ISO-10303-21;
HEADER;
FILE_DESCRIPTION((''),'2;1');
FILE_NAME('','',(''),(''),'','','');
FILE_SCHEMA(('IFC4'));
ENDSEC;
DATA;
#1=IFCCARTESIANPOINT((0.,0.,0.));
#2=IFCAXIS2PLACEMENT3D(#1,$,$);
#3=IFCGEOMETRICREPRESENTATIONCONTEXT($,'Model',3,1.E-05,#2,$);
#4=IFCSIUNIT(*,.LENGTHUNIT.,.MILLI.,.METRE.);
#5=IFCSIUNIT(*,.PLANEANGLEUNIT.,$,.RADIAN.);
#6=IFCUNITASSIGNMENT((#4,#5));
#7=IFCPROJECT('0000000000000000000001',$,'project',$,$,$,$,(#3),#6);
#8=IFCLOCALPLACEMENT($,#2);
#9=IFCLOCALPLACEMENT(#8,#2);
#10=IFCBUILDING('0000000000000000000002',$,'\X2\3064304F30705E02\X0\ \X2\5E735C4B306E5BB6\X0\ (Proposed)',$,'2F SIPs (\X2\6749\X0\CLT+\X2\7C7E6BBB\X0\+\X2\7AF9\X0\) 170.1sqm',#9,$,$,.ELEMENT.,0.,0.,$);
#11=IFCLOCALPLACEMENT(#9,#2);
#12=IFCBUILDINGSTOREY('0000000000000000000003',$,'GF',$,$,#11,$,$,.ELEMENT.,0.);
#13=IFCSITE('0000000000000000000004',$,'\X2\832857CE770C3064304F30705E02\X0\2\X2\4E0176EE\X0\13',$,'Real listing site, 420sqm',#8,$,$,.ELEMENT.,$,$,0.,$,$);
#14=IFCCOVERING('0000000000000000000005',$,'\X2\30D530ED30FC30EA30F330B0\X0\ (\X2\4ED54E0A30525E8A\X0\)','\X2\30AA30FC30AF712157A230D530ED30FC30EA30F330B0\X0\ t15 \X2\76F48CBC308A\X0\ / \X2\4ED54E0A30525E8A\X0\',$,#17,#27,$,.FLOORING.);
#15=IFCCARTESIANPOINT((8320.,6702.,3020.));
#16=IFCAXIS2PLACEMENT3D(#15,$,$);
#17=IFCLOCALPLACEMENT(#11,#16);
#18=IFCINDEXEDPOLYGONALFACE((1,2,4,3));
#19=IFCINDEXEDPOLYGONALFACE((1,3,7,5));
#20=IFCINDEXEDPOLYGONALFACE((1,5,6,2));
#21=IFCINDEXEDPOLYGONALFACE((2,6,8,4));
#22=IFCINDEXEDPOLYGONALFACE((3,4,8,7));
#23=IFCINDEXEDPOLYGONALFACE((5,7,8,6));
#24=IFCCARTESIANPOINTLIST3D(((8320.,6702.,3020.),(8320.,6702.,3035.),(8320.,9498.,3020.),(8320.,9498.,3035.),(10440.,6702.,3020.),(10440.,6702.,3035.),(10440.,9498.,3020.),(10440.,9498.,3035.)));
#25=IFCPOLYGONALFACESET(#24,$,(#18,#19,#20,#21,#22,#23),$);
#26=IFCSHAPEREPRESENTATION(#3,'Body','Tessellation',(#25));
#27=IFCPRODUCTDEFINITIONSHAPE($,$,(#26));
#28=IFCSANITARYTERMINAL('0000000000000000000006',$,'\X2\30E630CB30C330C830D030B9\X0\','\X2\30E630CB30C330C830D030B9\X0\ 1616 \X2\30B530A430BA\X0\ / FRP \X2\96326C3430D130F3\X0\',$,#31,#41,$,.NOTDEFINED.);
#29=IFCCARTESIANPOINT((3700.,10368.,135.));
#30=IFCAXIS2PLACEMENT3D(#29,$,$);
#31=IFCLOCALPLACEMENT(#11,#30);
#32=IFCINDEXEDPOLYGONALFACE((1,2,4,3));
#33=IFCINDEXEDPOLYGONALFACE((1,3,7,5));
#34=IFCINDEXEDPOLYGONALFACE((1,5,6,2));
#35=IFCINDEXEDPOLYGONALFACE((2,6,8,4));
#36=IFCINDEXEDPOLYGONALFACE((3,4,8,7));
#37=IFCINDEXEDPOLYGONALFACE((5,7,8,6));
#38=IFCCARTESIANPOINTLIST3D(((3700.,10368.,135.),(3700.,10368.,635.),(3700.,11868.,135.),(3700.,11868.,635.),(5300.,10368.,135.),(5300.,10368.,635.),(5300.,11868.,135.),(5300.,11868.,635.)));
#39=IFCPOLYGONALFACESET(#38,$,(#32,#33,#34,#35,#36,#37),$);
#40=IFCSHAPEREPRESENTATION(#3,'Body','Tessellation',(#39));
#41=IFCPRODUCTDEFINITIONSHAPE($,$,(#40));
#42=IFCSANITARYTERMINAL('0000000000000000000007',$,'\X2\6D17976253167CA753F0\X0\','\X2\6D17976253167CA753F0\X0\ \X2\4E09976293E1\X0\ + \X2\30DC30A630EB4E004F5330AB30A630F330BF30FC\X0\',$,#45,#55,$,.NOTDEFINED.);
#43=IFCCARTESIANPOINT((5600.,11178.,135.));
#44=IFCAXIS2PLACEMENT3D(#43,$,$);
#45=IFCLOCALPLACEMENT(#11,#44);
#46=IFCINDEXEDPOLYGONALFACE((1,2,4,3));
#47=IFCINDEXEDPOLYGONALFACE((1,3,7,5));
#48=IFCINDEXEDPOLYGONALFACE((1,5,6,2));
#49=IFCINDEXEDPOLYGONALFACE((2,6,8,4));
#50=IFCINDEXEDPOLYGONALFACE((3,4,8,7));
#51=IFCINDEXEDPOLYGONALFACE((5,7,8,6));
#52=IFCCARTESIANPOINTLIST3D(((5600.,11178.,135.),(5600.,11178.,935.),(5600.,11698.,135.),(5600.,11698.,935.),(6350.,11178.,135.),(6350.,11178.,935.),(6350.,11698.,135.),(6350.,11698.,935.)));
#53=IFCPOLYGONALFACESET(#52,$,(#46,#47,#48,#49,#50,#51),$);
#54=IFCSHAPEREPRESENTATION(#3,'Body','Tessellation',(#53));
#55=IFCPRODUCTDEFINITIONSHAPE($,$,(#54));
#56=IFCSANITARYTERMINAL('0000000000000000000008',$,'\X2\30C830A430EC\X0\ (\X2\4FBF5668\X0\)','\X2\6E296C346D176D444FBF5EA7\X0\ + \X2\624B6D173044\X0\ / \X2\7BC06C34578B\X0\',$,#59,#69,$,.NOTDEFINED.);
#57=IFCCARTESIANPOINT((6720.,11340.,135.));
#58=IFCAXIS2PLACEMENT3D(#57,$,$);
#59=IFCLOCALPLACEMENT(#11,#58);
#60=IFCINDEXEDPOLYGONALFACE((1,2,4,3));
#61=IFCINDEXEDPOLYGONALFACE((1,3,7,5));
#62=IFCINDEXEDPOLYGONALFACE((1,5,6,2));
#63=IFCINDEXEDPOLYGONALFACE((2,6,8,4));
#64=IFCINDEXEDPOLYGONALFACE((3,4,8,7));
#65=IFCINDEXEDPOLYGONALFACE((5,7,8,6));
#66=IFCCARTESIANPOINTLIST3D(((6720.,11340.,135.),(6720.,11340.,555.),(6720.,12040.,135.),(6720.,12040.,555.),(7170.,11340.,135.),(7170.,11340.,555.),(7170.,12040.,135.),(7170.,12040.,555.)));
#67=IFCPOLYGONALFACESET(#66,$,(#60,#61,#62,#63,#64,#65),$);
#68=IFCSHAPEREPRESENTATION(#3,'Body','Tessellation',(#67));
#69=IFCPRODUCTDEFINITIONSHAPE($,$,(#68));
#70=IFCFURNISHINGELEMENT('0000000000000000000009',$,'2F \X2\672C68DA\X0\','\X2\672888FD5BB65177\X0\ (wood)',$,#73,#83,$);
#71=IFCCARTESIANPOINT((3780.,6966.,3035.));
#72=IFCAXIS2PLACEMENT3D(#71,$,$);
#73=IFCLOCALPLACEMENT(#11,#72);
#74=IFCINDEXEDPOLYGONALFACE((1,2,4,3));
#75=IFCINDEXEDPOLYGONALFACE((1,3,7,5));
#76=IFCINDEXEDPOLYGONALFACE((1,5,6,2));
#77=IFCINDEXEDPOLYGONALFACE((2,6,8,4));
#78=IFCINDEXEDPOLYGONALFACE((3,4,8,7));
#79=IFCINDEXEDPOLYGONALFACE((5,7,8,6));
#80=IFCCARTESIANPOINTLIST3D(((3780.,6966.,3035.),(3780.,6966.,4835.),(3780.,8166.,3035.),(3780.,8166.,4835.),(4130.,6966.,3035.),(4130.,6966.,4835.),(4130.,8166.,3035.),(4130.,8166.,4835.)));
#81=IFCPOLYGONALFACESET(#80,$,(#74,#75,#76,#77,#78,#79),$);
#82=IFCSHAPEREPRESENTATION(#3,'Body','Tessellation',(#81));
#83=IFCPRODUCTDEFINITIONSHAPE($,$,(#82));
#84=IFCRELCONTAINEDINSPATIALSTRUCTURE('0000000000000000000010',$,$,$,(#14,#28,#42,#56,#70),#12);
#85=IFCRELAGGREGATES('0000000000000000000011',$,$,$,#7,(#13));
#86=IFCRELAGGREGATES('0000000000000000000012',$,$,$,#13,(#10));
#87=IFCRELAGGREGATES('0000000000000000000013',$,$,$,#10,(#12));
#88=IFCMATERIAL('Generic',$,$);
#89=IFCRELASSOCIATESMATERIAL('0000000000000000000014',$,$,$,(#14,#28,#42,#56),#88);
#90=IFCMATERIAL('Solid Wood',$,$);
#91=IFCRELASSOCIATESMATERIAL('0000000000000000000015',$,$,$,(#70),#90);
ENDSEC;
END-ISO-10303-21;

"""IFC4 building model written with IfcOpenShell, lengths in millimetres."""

from ifc_helpers import new_model, si_unit, frame, frame_2d, origin, place, context, project, spatial, rectangle, extrude, material, element, save


model = new_model("IFC4")

# Units and contexts
model_context = context("Model", 3, precision=1e-05, world=origin())
ifc_project = project(units=[si_unit("LENGTHUNIT", "METRE", prefix="MILLI"), si_unit("PLANEANGLEUNIT", "RADIAN")], contexts=[model_context])

# Site, building, storey
site_placement = place(None, origin())
site = spatial("IfcSite", under=ifc_project, at=site_placement, Name="茨城県つくば市2丁目13", ObjectType="Real listing site, 420sqm", CompositionType="ELEMENT", RefElevation=0.0)
building_placement = place(site_placement, origin())
building = spatial("IfcBuilding", under=site, at=building_placement, Name="つくば市 平屋の家 (Proposed)", ObjectType="2F SIPs (杉CLT+籾殻+竹) 170.1sqm", CompositionType="ELEMENT", ElevationOfRefHeight=0.0, ElevationOfTerrain=0.0)
storey_placement = place(building_placement, origin())
storey = spatial("IfcBuildingStorey", under=building, at=storey_placement, Name="GF", CompositionType="ELEMENT", Elevation=0.0)

# Shared definitions
ifc_material_1 = material(Name="Solid Wood")
ifc_material_2 = material(Name="Generic")

# Covering
covering_1_placement = place(storey_placement, frame((8320.0, 6702.0, 3020.0)))
element("IfcCovering", 1, at=covering_1_placement, inside=storey, material=ifc_material_2, Name="フローリング (仕上げ床)", Description="オーク無垢フローリング t15 直貼り / 仕上げ床", PredefinedType="FLOORING", context=model_context, shape_type="SweptSolid", body=[
    extrude(rectangle(XDim=2120.0, YDim=2796.0, at=frame_2d((1060.0, 1398.0))), frame((8320.0, 6702.0, 3020.0)), (0.0, 0.0, 1.0), 15.0),
])

# Sanitary terminals
sanitary_terminal_1_placement = place(storey_placement, frame((3700.0, 10368.0, 135.0)))
element("IfcSanitaryTerminal", 2, at=sanitary_terminal_1_placement, inside=storey, material=ifc_material_2, Name="ユニットバス", Description="ユニットバス 1616 サイズ / FRP 防水パン", PredefinedType="NOTDEFINED", context=model_context, shape_type="SweptSolid", body=[
    extrude(rectangle(XDim=1600.0, YDim=1500.0, at=frame_2d((800.0, 750.0))), frame((3700.0, 10368.0, 135.0)), (0.0, 0.0, 1.0), 500.0),
])
sanitary_terminal_2_placement = place(storey_placement, frame((5600.0, 11178.0, 135.0)))
element("IfcSanitaryTerminal", 3, at=sanitary_terminal_2_placement, inside=storey, material=ifc_material_2, Name="洗面化粧台", Description="洗面化粧台 三面鏡 + ボウル一体カウンター", PredefinedType="NOTDEFINED", context=model_context, shape_type="SweptSolid", body=[
    extrude(rectangle(XDim=750.0, YDim=520.0, at=frame_2d((375.0, 260.0))), frame((5600.0, 11178.0, 135.0)), (0.0, 0.0, 1.0), 800.0),
])
sanitary_terminal_3_placement = place(storey_placement, frame((6720.0, 11340.0, 135.0)))
element("IfcSanitaryTerminal", 4, at=sanitary_terminal_3_placement, inside=storey, material=ifc_material_2, Name="トイレ (便器)", Description="温水洗浄便座 + 手洗い / 節水型", PredefinedType="NOTDEFINED", context=model_context, shape_type="SweptSolid", body=[
    extrude(rectangle(XDim=450.0, YDim=700.0, at=frame_2d((225.0, 350.0))), frame((6720.0, 11340.0, 135.0)), (0.0, 0.0, 1.0), 420.0),
])

# Furnishing element
furnishing_placement = place(storey_placement, frame((3780.0, 6966.0, 3035.0)))
element("IfcFurnishingElement", 5, at=furnishing_placement, inside=storey, material=ifc_material_1, Name="2F 本棚", Description="木製家具 (wood)", context=model_context, shape_type="SweptSolid", body=[
    extrude(rectangle(XDim=350.0, YDim=1200.0, at=frame_2d((175.0, 600.0))), frame((3780.0, 6966.0, 3035.0)), (0.0, 0.0, 1.0), 1800.0),
])

save(model, "model.ifc")
